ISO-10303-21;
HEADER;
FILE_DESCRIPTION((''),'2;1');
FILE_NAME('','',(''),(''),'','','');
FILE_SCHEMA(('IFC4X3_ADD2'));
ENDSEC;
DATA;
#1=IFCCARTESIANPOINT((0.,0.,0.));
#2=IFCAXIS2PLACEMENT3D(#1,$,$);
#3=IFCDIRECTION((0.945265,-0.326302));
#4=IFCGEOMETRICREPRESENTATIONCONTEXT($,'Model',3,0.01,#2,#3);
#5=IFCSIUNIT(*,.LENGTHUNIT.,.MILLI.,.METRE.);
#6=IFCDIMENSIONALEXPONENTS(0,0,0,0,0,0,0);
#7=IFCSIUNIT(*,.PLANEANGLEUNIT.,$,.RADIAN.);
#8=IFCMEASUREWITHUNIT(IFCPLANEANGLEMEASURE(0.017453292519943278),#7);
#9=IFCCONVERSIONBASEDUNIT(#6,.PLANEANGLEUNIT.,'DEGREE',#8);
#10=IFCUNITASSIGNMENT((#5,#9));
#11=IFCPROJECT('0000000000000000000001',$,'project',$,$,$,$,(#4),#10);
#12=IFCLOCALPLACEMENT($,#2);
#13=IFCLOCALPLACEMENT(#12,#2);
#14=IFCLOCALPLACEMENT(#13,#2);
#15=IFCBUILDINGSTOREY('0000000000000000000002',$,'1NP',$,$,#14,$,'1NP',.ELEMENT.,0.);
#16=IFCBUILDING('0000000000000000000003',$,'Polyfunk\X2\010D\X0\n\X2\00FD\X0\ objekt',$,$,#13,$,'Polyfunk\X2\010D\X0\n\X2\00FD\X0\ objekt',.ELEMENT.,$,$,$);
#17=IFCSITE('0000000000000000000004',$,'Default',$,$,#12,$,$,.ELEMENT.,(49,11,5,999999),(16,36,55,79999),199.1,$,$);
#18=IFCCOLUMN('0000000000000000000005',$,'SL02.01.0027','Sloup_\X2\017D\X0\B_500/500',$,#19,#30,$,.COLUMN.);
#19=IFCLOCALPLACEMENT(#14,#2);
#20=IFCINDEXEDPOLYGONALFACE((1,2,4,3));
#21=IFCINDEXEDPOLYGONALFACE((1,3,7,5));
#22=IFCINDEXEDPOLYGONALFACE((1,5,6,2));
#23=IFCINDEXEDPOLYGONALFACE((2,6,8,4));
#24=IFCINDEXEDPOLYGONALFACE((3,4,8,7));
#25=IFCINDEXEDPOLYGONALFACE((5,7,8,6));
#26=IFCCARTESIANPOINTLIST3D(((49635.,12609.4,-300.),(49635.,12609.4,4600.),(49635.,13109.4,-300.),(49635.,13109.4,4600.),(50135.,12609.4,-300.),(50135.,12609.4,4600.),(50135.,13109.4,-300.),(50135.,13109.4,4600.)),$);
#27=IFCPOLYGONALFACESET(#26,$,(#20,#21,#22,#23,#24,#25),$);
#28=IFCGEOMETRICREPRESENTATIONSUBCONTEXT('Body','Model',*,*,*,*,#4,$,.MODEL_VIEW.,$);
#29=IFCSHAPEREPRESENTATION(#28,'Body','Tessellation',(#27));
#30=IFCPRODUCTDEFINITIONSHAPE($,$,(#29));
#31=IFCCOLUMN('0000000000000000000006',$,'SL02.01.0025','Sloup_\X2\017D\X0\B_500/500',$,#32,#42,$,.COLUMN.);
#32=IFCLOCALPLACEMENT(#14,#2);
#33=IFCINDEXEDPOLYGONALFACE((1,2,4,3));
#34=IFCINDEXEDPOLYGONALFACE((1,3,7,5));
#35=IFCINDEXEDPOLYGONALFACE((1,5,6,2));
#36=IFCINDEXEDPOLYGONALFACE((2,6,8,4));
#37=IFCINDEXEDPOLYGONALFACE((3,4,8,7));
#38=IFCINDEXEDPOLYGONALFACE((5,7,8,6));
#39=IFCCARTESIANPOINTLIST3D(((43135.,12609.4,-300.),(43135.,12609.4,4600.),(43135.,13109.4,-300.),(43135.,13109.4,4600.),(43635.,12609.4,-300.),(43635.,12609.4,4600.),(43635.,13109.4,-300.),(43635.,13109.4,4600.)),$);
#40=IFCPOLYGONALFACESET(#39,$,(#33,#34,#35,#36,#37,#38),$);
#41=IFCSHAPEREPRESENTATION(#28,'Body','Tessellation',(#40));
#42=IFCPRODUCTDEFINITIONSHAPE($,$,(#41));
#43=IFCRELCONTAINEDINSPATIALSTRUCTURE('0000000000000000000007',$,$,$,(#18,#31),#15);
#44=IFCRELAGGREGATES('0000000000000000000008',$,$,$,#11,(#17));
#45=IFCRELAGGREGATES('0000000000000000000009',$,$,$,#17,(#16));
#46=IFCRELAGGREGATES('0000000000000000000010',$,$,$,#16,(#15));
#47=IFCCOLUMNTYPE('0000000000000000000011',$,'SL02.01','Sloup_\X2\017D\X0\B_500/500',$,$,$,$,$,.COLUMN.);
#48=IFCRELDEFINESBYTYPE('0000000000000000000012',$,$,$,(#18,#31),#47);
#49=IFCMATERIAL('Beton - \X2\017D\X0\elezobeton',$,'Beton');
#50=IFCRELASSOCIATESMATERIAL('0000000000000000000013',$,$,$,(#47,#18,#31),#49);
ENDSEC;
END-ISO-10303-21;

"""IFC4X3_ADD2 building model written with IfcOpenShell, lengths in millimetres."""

from ifc_helpers import new_model, entity, si_unit, converted_unit, direction, frame, frame_2d, origin, origin_2d_with_axis, place, context, subcontext, project, spatial, rectangle, extrude, source, transform, mapped, material, material_profile, profile_set, profile_usage, type_object, element, save


model = new_model("IFC4X3_ADD2")

# Units and contexts
model_context = context("Model", 3, precision=0.01, world=origin(), true_north=direction((0.945265, -0.326302)))
body_context = subcontext(model_context, "Body", "Model", "MODEL_VIEW")
ifc_project = project(units=[si_unit("LENGTHUNIT", "METRE", prefix="MILLI"), converted_unit("PLANEANGLEUNIT", "DEGREE", entity("IfcPlaneAngleMeasure", 0.017453292519943278), si_unit("PLANEANGLEUNIT", "RADIAN"), dimensions=[0, 0, 0, 0, 0, 0, 0])], contexts=[model_context])

# Site, building, storey
site_placement = place(None, origin())
site = spatial("IfcSite", under=ifc_project, at=site_placement, Name="Default", CompositionType="ELEMENT", RefLatitude=(49, 11, 5, 999999), RefLongitude=(16, 36, 55, 79999), RefElevation=199.1)
building_placement = place(site_placement, origin())
building = spatial("IfcBuilding", under=site, at=building_placement, Name="Polyfunkčný objekt", LongName="Polyfunkčný objekt", CompositionType="ELEMENT")
storey_placement = place(building_placement, origin())
storey = spatial("IfcBuildingStorey", under=building, at=storey_placement, Name="1NP", LongName="1NP", CompositionType="ELEMENT", Elevation=0.0)

# Columns
ifc_material = material(Name="Beton - Železobeton", Category="Beton")
ifc_material_profile_1 = material_profile(ifc_material, rectangle(XDim=500.0, YDim=500.0, at=frame_2d((0.0, 0.0), x_axis=(1.0, 0.0))), Name="Sloup_ŽB_500/500")
ifc_profile_set_1 = profile_set([ifc_material_profile_1], Name="Sloup_ŽB_500/500")
ifc_profile_usage_1 = profile_usage(ifc_profile_set_1)
column_type_1 = type_object("IfcColumnType", Name="SL02.01", Description="Sloup_ŽB_500/500", PredefinedType="COLUMN", material=ifc_profile_set_1)
shared_shape_1 = source(origin(), body_context, "Body", "SweptSolid", [
    extrude(rectangle(XDim=500.0, YDim=500.0, at=frame_2d((0.0, -50.0), x_axis=(1.0, 0.0))), frame((49885.0, 12809.4, -300.0), z_axis=(0.0, 0.0, 1.0), x_axis=(-1.0, 0.0, 0.0)), (0.0, 0.0, 1.0), 4900.0),
])
column_1_placement = place(storey_placement, origin())
element("IfcColumn", 1, at=column_1_placement, inside=storey, type_object=column_type_1, material=ifc_profile_usage_1, Name="SL02.01.0027", Description="Sloup_ŽB_500/500", PredefinedType="COLUMN", context=body_context, shape_type="MappedRepresentation", body=[
    mapped(shared_shape_1, transform((0.0, 0.0, 0.0), scale=1.0)),
])
shared_shape_2 = source(origin(), body_context, "Body", "SweptSolid", [
    extrude(rectangle(XDim=500.0, YDim=500.0, at=origin_2d_with_axis()), frame((43385.0, 12859.4, -300.0), z_axis=(0.0, 0.0, 1.0), x_axis=(0.0, 1.0, 0.0)), (0.0, 0.0, 1.0), 4900.0),
])
column_2_placement = place(storey_placement, origin())
element("IfcColumn", 2, at=column_2_placement, inside=storey, type_object=column_type_1, material=ifc_profile_usage_1, Name="SL02.01.0025", Description="Sloup_ŽB_500/500", PredefinedType="COLUMN", context=body_context, shape_type="MappedRepresentation", body=[
    mapped(shared_shape_2, transform((0.0, 0.0, 0.0), scale=1.0)),
])

save(model, "model.ifc")
